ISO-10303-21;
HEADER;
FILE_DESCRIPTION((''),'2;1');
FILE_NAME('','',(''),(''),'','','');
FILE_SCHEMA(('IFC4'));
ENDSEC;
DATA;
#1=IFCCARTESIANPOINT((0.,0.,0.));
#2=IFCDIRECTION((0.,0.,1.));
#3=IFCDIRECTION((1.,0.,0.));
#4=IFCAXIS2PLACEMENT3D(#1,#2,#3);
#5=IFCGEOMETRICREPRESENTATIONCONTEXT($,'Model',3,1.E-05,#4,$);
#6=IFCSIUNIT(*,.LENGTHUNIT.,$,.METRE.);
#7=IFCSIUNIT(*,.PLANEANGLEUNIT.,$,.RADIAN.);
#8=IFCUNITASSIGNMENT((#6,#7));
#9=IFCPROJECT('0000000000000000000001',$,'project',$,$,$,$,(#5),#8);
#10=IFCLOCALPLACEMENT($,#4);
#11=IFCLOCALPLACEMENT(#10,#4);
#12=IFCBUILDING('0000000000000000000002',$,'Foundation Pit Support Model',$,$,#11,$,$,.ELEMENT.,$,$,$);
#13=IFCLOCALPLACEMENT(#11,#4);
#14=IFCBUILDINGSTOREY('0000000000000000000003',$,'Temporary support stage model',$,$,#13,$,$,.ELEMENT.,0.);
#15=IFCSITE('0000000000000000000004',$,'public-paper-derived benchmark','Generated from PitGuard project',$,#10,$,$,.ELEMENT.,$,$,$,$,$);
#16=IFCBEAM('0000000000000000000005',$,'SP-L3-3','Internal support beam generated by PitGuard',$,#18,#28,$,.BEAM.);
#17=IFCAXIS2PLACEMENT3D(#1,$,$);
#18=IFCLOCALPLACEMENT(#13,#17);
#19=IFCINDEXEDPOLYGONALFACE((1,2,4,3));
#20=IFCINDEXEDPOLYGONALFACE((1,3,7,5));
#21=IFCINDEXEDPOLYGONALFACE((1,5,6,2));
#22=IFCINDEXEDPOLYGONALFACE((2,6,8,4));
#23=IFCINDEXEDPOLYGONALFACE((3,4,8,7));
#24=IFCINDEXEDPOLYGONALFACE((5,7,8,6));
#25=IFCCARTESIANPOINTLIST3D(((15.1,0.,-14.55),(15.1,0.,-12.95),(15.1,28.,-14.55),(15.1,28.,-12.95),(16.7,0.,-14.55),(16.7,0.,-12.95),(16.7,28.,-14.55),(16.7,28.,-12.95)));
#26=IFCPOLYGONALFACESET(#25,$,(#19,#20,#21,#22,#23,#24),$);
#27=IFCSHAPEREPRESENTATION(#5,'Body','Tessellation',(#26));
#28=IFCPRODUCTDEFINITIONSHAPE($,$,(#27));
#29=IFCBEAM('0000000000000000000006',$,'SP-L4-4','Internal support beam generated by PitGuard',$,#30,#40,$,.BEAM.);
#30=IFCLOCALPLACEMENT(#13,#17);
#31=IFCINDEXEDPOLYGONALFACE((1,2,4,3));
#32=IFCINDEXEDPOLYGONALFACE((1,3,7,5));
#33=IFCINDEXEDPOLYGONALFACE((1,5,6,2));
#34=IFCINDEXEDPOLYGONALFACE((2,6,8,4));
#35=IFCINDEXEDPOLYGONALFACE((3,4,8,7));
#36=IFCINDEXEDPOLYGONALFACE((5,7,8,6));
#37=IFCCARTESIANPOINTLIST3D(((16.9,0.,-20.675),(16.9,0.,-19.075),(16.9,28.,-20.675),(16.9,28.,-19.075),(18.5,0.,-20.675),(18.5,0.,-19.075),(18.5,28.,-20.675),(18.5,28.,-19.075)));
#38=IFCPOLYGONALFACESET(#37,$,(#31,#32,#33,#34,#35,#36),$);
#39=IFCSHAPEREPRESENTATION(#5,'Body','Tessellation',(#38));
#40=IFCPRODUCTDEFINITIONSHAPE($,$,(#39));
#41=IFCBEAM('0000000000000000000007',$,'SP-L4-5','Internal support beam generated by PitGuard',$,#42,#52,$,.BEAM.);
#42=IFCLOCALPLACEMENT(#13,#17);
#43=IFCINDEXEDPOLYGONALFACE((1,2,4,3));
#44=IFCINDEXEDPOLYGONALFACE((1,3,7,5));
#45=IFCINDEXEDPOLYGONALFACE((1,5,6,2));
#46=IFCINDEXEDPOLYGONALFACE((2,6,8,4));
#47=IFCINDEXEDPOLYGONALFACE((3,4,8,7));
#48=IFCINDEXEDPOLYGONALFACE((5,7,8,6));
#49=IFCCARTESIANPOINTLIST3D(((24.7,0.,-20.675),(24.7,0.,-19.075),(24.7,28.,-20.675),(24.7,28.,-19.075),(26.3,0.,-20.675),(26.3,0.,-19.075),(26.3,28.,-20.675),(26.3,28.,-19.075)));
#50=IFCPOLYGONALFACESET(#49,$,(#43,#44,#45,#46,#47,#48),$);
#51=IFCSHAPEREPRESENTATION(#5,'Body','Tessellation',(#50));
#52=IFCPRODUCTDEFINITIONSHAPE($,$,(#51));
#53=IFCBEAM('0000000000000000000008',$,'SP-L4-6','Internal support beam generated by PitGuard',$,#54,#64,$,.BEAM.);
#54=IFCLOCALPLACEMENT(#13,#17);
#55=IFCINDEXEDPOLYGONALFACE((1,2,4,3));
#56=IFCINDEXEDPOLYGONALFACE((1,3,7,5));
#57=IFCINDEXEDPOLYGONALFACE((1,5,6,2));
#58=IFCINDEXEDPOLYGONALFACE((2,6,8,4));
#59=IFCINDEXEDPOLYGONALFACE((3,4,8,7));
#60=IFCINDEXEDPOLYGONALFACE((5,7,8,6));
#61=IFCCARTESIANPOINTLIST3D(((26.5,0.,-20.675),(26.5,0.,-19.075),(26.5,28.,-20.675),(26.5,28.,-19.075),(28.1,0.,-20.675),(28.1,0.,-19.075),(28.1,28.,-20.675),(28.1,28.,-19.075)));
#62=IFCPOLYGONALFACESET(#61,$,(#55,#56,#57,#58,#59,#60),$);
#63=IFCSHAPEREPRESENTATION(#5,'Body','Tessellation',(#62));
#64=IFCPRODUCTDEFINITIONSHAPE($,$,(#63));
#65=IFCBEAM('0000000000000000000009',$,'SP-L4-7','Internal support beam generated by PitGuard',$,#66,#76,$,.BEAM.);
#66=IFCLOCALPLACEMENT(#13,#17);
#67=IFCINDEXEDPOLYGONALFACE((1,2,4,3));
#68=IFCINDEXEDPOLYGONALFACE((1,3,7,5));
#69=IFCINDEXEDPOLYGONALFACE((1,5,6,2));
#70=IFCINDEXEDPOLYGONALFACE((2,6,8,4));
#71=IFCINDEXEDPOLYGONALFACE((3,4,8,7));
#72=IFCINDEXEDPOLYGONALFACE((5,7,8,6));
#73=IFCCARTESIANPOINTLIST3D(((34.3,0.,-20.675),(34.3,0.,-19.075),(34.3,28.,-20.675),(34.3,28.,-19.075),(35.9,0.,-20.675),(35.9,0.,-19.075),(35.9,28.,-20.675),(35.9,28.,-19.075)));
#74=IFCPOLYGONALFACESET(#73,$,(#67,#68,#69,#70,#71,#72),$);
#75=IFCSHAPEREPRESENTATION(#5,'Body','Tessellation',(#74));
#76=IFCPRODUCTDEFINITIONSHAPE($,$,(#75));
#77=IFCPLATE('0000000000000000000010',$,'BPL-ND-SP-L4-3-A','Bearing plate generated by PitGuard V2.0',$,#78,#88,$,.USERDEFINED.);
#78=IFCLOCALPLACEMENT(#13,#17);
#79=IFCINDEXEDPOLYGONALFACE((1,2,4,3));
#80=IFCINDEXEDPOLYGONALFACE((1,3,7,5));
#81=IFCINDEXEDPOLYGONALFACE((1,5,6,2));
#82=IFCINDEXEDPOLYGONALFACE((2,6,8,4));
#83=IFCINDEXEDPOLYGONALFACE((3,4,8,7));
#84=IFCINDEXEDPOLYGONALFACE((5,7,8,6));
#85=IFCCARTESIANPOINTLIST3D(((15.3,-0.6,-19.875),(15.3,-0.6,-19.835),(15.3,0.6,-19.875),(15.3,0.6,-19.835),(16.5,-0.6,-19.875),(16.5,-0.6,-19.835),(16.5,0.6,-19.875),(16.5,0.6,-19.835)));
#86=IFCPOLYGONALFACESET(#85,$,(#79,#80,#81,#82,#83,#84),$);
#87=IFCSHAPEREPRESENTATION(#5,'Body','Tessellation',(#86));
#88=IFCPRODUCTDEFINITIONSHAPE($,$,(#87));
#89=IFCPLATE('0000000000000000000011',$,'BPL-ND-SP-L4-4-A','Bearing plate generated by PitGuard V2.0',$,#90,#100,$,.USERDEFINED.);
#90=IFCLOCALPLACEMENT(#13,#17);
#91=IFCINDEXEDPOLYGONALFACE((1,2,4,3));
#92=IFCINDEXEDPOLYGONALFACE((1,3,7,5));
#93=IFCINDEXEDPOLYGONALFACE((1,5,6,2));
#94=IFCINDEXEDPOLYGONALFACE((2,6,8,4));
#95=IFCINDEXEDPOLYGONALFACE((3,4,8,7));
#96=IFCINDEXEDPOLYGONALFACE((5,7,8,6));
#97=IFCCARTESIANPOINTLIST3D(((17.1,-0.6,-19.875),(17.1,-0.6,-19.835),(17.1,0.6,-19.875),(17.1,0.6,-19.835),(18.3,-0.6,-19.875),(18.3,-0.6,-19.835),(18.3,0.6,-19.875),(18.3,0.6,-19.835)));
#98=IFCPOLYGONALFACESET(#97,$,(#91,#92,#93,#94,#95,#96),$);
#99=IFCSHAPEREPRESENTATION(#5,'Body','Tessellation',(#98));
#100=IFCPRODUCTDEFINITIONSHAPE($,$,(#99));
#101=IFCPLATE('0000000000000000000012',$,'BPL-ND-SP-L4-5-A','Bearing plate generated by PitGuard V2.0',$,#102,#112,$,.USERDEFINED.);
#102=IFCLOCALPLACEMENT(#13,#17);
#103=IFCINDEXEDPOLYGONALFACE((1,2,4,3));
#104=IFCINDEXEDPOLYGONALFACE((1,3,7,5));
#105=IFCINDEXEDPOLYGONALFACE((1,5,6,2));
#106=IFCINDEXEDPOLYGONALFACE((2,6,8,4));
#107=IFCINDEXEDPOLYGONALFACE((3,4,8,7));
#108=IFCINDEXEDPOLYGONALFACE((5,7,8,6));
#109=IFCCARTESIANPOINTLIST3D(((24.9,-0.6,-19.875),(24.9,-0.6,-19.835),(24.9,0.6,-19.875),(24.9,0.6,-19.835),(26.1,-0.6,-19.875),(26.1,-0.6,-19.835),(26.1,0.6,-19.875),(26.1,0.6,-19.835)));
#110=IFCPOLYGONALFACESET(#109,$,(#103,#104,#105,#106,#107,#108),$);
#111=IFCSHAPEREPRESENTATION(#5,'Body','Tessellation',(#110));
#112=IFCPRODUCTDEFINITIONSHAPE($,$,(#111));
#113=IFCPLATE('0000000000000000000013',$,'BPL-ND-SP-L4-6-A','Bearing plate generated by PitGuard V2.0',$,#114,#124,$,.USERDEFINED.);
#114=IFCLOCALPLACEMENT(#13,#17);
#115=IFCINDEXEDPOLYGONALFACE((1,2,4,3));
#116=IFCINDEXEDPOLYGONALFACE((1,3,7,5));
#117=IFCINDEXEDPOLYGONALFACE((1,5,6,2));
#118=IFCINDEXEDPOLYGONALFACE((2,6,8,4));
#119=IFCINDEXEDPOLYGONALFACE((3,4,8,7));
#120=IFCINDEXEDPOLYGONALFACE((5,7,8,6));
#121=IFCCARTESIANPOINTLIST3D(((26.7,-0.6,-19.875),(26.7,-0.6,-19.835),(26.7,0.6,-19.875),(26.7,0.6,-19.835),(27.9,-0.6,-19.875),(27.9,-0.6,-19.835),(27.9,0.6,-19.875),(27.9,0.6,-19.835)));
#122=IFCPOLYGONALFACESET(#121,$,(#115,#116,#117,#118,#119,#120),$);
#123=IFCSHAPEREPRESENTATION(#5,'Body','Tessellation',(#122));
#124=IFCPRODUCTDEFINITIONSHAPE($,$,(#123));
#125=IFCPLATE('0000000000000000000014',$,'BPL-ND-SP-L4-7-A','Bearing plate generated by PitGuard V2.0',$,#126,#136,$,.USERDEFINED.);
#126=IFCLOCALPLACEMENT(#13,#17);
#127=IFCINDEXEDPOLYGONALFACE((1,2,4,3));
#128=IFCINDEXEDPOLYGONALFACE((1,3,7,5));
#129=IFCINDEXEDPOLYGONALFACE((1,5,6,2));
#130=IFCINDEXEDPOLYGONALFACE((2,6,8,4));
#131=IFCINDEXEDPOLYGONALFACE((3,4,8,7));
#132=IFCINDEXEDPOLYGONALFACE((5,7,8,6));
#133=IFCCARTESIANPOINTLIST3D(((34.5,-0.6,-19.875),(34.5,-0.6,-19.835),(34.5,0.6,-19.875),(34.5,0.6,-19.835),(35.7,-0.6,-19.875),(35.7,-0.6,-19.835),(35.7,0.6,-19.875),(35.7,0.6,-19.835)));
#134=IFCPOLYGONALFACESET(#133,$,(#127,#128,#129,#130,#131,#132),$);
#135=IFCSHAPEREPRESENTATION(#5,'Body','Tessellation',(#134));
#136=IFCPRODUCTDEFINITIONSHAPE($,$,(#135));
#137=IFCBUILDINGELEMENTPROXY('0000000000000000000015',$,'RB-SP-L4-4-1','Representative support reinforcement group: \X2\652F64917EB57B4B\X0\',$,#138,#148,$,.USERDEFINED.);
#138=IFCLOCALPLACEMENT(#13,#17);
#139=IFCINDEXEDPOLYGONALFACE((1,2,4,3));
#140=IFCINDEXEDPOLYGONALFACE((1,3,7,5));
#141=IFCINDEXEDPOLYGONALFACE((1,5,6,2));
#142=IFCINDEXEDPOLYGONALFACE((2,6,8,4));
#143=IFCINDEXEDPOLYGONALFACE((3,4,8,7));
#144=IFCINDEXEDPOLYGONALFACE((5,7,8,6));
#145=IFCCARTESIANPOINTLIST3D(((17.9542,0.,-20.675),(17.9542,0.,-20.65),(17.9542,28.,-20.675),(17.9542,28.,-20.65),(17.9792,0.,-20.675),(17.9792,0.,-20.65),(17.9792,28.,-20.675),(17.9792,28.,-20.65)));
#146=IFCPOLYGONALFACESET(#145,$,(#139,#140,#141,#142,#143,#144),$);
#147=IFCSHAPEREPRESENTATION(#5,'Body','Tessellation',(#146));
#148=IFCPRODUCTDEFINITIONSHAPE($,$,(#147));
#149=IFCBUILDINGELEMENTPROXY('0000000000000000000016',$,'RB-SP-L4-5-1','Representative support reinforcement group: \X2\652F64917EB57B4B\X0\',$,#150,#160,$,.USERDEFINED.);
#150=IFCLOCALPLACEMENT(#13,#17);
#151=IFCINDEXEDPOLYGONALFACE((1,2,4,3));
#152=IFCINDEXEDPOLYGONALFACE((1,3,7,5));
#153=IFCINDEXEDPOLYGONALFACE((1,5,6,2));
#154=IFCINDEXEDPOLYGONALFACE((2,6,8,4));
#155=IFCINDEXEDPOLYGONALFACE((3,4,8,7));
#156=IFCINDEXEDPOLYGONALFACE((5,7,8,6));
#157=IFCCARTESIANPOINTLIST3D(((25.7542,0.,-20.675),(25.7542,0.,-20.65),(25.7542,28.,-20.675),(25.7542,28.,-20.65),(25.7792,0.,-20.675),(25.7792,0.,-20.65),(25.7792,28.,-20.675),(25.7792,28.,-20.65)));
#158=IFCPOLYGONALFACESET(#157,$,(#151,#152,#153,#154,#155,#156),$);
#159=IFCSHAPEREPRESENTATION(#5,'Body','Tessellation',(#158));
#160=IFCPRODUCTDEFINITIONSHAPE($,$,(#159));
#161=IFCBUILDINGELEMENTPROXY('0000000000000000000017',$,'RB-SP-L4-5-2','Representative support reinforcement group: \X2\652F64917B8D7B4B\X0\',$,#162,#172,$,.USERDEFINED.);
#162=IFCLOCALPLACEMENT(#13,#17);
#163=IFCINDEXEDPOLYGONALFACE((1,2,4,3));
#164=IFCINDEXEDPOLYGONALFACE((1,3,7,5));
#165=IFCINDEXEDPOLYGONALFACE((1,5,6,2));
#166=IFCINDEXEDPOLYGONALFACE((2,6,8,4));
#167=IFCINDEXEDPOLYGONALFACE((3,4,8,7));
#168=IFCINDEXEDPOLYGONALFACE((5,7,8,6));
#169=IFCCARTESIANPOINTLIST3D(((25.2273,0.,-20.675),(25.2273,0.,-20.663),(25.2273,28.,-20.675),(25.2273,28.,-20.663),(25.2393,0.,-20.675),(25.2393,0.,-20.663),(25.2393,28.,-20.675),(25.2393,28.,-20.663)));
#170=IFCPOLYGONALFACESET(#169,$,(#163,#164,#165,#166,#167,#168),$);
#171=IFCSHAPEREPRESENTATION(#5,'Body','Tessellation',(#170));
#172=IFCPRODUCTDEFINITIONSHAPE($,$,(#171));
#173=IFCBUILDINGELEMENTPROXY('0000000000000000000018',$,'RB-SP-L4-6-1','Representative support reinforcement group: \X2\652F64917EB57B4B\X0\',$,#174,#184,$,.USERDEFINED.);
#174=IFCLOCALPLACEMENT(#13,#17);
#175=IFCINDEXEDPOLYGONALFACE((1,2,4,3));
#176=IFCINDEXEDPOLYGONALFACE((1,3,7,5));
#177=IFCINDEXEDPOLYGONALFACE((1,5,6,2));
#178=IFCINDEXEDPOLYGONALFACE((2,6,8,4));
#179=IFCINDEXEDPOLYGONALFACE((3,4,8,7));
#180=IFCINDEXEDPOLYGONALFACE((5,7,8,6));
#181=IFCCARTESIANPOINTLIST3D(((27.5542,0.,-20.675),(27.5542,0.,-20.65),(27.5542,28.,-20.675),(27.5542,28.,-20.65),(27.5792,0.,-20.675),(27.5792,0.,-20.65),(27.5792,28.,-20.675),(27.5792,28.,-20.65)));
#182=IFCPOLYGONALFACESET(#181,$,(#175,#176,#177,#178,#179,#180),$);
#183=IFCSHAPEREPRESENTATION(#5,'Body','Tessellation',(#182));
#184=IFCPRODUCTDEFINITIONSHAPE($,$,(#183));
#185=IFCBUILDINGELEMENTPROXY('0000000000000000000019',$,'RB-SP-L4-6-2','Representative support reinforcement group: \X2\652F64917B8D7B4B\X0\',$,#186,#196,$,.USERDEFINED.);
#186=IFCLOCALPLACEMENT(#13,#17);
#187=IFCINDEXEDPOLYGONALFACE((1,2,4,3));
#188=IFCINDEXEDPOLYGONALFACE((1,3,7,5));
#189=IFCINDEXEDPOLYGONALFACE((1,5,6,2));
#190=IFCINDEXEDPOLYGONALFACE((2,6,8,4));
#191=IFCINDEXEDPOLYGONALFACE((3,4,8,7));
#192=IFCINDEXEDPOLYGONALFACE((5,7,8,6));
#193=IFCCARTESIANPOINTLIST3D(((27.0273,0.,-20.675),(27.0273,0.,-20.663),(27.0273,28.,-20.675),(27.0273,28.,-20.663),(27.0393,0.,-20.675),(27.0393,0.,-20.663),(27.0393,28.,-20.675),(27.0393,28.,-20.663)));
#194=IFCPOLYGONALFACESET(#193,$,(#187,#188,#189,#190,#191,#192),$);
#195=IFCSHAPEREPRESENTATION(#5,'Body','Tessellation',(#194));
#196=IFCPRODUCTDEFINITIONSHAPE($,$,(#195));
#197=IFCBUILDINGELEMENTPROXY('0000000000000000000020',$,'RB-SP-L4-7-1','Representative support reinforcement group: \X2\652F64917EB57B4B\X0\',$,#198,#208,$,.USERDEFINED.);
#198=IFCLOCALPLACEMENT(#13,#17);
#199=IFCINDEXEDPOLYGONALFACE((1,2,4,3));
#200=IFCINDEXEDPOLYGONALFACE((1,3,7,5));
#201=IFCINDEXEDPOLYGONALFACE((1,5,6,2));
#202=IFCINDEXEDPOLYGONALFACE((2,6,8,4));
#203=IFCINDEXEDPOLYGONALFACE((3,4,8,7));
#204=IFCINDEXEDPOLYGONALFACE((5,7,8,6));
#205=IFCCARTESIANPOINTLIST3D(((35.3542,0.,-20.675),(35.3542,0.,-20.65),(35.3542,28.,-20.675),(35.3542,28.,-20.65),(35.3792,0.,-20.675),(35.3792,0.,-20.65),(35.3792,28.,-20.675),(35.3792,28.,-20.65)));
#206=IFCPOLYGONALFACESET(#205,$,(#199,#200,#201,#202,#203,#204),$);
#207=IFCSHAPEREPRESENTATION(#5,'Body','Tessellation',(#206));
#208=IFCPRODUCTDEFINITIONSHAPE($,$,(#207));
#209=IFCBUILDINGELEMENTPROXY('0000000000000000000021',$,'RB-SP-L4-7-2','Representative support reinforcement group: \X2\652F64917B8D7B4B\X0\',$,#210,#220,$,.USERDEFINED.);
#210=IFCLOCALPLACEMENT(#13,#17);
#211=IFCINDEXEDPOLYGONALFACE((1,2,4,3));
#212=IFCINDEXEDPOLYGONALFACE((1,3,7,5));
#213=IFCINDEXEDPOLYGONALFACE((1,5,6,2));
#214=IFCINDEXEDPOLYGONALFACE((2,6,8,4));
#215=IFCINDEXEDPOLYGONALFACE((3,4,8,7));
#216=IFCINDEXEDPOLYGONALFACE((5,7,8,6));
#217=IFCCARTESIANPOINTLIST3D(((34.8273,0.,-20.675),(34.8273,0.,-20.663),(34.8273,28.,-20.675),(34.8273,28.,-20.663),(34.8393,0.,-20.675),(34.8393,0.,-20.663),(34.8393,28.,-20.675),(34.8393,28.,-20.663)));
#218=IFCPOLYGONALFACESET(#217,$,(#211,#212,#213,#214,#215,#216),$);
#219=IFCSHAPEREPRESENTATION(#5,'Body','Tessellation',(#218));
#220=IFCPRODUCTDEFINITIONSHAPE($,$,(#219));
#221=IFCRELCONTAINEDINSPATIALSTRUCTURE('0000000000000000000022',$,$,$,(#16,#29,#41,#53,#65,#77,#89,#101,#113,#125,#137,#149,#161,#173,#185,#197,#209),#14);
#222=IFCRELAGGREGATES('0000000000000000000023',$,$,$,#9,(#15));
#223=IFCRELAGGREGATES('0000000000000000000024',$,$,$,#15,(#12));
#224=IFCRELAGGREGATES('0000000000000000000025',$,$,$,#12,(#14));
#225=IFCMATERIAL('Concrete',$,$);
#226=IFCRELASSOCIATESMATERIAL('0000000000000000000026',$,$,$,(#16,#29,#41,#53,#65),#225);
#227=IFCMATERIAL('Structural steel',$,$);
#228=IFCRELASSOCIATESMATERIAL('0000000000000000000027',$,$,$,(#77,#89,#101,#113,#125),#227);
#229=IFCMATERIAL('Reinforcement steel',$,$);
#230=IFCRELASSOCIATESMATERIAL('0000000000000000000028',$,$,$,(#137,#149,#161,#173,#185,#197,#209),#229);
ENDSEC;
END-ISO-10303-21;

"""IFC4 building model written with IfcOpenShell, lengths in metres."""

from ifc_helpers import new_model, si_unit, frame, origin_with_axes, origin_2d, place, context, project, spatial, rectangle, extrude, material, element, save


model = new_model("IFC4")

# Units and contexts
model_context = context("Model", 3, precision=1e-05, world=origin_with_axes())
ifc_project = project(units=[si_unit("LENGTHUNIT", "METRE"), si_unit("PLANEANGLEUNIT", "RADIAN")], contexts=[model_context])

# Site, building, storey
site_placement = place(None, origin_with_axes())
site = spatial("IfcSite", under=ifc_project, at=site_placement, Name="public-paper-derived benchmark", Description="Generated from PitGuard project", CompositionType="ELEMENT")
building_placement = place(site_placement, origin_with_axes())
building = spatial("IfcBuilding", under=site, at=building_placement, Name="Foundation Pit Support Model", CompositionType="ELEMENT")
storey_placement = place(building_placement, origin_with_axes())
storey = spatial("IfcBuildingStorey", under=building, at=storey_placement, Name="Temporary support stage model", CompositionType="ELEMENT", Elevation=0.0)

# Beams
ifc_material_1 = material(Name="Concrete")
for number, where, z_axis, x_axis, name in (
    (1, (15.9, 14.0, -14.55), (0.0, 0.0, 1.0), (0.0, 1.0, 0.0), "SP-L3-3"),
    (2, (17.7, 14.0, -20.675), (0.0, 0.0, 1.0), (0.0, 1.0, 0.0), "SP-L4-4"),
    (3, (25.5, 14.0, -20.675), (0.0, 0.0, 1.0), (0.0, 1.0, 0.0), "SP-L4-5"),
    (4, (27.3, 14.0, -20.675), (0.0, 0.0, 1.0), (0.0, 1.0, 0.0), "SP-L4-6"),
    (5, (35.1, 14.0, -20.675), (0.0, 0.0, 1.0), (0.0, 1.0, 0.0), "SP-L4-7"),
):
    element("IfcBeam", number, at=place(storey_placement, frame(where, z_axis=z_axis, x_axis=x_axis)), inside=storey, material=ifc_material_1, Name=name, Description="Internal support beam generated by PitGuard", PredefinedType="BEAM", context=model_context, shape_type="SweptSolid", body=[
        extrude(rectangle(XDim=28.0, YDim=1.6, at=origin_2d()), origin_with_axes(), (0.0, 0.0, 1.0), 1.6),
    ])

# Plates
ifc_material_2 = material(Name="Structural steel")
for number, where, z_axis, x_axis, name in (
    (6, (15.9, 0.0, -19.875), (0.0, 0.0, 1.0), (1.0, 0.0, 0.0), "BPL-ND-SP-L4-3-A"),
    (7, (17.7, 0.0, -19.875), (0.0, 0.0, 1.0), (1.0, 0.0, 0.0), "BPL-ND-SP-L4-4-A"),
    (8, (25.5, 0.0, -19.875), (0.0, 0.0, 1.0), (1.0, 0.0, 0.0), "BPL-ND-SP-L4-5-A"),
    (9, (27.3, 0.0, -19.875), (0.0, 0.0, 1.0), (1.0, 0.0, 0.0), "BPL-ND-SP-L4-6-A"),
    (10, (35.1, 0.0, -19.875), (0.0, 0.0, 1.0), (1.0, 0.0, 0.0), "BPL-ND-SP-L4-7-A"),
):
    element("IfcPlate", number, at=place(storey_placement, frame(where, z_axis=z_axis, x_axis=x_axis)), inside=storey, material=ifc_material_2, Name=name, Description="Bearing plate generated by PitGuard V2.0", PredefinedType="USERDEFINED", context=model_context, shape_type="SweptSolid", body=[
        extrude(rectangle(XDim=1.2, YDim=1.2, at=origin_2d()), origin_with_axes(), (0.0, 0.0, 1.0), 0.04),
    ])

# Building element proxies
ifc_material_3 = material(Name="Reinforcement steel")
for number, where, z_axis, x_axis, name in (
    (11, (17.9667, 14.0, -20.675), (0.0, 0.0, 1.0), (0.0, 1.0, 0.0), "RB-SP-L4-4-1"),
    (12, (25.7667, 14.0, -20.675), (0.0, 0.0, 1.0), (0.0, 1.0, 0.0), "RB-SP-L4-5-1"),
):
    element("IfcBuildingElementProxy", number, at=place(storey_placement, frame(where, z_axis=z_axis, x_axis=x_axis)), inside=storey, material=ifc_material_3, Name=name, Description="Representative support reinforcement group: 支撑纵筋", PredefinedType="USERDEFINED", context=model_context, shape_type="SweptSolid", body=[
        extrude(rectangle(XDim=28.0, YDim=0.025, at=origin_2d()), origin_with_axes(), (0.0, 0.0, 1.0), 0.025),
    ])
proxy_1_placement = place(storey_placement, frame((25.2333, 14.0, -20.675), z_axis=(0.0, 0.0, 1.0), x_axis=(0.0, 1.0, 0.0)))
element("IfcBuildingElementProxy", 13, at=proxy_1_placement, inside=storey, material=ifc_material_3, Name="RB-SP-L4-5-2", Description="Representative support reinforcement group: 支撑箍筋", PredefinedType="USERDEFINED", context=model_context, shape_type="SweptSolid", body=[
    extrude(rectangle(XDim=28.0, YDim=0.012, at=origin_2d()), origin_with_axes(), (0.0, 0.0, 1.0), 0.012),
])
proxy_2_placement = place(storey_placement, frame((27.5667, 14.0, -20.675), z_axis=(0.0, 0.0, 1.0), x_axis=(0.0, 1.0, 0.0)))
element("IfcBuildingElementProxy", 14, at=proxy_2_placement, inside=storey, material=ifc_material_3, Name="RB-SP-L4-6-1", Description="Representative support reinforcement group: 支撑纵筋", PredefinedType="USERDEFINED", context=model_context, shape_type="SweptSolid", body=[
    extrude(rectangle(XDim=28.0, YDim=0.025, at=origin_2d()), origin_with_axes(), (0.0, 0.0, 1.0), 0.025),
])
proxy_3_placement = place(storey_placement, frame((27.0333, 14.0, -20.675), z_axis=(0.0, 0.0, 1.0), x_axis=(0.0, 1.0, 0.0)))
element("IfcBuildingElementProxy", 15, at=proxy_3_placement, inside=storey, material=ifc_material_3, Name="RB-SP-L4-6-2", Description="Representative support reinforcement group: 支撑箍筋", PredefinedType="USERDEFINED", context=model_context, shape_type="SweptSolid", body=[
    extrude(rectangle(XDim=28.0, YDim=0.012, at=origin_2d()), origin_with_axes(), (0.0, 0.0, 1.0), 0.012),
])
proxy_4_placement = place(storey_placement, frame((35.3667, 14.0, -20.675), z_axis=(0.0, 0.0, 1.0), x_axis=(0.0, 1.0, 0.0)))
element("IfcBuildingElementProxy", 16, at=proxy_4_placement, inside=storey, material=ifc_material_3, Name="RB-SP-L4-7-1", Description="Representative support reinforcement group: 支撑纵筋", PredefinedType="USERDEFINED", context=model_context, shape_type="SweptSolid", body=[
    extrude(rectangle(XDim=28.0, YDim=0.025, at=origin_2d()), origin_with_axes(), (0.0, 0.0, 1.0), 0.025),
])
proxy_5_placement = place(storey_placement, frame((34.8333, 14.0, -20.675), z_axis=(0.0, 0.0, 1.0), x_axis=(0.0, 1.0, 0.0)))
element("IfcBuildingElementProxy", 17, at=proxy_5_placement, inside=storey, material=ifc_material_3, Name="RB-SP-L4-7-2", Description="Representative support reinforcement group: 支撑箍筋", PredefinedType="USERDEFINED", context=model_context, shape_type="SweptSolid", body=[
    extrude(rectangle(XDim=28.0, YDim=0.012, at=origin_2d()), origin_with_axes(), (0.0, 0.0, 1.0), 0.012),
])

save(model, "model.ifc")
